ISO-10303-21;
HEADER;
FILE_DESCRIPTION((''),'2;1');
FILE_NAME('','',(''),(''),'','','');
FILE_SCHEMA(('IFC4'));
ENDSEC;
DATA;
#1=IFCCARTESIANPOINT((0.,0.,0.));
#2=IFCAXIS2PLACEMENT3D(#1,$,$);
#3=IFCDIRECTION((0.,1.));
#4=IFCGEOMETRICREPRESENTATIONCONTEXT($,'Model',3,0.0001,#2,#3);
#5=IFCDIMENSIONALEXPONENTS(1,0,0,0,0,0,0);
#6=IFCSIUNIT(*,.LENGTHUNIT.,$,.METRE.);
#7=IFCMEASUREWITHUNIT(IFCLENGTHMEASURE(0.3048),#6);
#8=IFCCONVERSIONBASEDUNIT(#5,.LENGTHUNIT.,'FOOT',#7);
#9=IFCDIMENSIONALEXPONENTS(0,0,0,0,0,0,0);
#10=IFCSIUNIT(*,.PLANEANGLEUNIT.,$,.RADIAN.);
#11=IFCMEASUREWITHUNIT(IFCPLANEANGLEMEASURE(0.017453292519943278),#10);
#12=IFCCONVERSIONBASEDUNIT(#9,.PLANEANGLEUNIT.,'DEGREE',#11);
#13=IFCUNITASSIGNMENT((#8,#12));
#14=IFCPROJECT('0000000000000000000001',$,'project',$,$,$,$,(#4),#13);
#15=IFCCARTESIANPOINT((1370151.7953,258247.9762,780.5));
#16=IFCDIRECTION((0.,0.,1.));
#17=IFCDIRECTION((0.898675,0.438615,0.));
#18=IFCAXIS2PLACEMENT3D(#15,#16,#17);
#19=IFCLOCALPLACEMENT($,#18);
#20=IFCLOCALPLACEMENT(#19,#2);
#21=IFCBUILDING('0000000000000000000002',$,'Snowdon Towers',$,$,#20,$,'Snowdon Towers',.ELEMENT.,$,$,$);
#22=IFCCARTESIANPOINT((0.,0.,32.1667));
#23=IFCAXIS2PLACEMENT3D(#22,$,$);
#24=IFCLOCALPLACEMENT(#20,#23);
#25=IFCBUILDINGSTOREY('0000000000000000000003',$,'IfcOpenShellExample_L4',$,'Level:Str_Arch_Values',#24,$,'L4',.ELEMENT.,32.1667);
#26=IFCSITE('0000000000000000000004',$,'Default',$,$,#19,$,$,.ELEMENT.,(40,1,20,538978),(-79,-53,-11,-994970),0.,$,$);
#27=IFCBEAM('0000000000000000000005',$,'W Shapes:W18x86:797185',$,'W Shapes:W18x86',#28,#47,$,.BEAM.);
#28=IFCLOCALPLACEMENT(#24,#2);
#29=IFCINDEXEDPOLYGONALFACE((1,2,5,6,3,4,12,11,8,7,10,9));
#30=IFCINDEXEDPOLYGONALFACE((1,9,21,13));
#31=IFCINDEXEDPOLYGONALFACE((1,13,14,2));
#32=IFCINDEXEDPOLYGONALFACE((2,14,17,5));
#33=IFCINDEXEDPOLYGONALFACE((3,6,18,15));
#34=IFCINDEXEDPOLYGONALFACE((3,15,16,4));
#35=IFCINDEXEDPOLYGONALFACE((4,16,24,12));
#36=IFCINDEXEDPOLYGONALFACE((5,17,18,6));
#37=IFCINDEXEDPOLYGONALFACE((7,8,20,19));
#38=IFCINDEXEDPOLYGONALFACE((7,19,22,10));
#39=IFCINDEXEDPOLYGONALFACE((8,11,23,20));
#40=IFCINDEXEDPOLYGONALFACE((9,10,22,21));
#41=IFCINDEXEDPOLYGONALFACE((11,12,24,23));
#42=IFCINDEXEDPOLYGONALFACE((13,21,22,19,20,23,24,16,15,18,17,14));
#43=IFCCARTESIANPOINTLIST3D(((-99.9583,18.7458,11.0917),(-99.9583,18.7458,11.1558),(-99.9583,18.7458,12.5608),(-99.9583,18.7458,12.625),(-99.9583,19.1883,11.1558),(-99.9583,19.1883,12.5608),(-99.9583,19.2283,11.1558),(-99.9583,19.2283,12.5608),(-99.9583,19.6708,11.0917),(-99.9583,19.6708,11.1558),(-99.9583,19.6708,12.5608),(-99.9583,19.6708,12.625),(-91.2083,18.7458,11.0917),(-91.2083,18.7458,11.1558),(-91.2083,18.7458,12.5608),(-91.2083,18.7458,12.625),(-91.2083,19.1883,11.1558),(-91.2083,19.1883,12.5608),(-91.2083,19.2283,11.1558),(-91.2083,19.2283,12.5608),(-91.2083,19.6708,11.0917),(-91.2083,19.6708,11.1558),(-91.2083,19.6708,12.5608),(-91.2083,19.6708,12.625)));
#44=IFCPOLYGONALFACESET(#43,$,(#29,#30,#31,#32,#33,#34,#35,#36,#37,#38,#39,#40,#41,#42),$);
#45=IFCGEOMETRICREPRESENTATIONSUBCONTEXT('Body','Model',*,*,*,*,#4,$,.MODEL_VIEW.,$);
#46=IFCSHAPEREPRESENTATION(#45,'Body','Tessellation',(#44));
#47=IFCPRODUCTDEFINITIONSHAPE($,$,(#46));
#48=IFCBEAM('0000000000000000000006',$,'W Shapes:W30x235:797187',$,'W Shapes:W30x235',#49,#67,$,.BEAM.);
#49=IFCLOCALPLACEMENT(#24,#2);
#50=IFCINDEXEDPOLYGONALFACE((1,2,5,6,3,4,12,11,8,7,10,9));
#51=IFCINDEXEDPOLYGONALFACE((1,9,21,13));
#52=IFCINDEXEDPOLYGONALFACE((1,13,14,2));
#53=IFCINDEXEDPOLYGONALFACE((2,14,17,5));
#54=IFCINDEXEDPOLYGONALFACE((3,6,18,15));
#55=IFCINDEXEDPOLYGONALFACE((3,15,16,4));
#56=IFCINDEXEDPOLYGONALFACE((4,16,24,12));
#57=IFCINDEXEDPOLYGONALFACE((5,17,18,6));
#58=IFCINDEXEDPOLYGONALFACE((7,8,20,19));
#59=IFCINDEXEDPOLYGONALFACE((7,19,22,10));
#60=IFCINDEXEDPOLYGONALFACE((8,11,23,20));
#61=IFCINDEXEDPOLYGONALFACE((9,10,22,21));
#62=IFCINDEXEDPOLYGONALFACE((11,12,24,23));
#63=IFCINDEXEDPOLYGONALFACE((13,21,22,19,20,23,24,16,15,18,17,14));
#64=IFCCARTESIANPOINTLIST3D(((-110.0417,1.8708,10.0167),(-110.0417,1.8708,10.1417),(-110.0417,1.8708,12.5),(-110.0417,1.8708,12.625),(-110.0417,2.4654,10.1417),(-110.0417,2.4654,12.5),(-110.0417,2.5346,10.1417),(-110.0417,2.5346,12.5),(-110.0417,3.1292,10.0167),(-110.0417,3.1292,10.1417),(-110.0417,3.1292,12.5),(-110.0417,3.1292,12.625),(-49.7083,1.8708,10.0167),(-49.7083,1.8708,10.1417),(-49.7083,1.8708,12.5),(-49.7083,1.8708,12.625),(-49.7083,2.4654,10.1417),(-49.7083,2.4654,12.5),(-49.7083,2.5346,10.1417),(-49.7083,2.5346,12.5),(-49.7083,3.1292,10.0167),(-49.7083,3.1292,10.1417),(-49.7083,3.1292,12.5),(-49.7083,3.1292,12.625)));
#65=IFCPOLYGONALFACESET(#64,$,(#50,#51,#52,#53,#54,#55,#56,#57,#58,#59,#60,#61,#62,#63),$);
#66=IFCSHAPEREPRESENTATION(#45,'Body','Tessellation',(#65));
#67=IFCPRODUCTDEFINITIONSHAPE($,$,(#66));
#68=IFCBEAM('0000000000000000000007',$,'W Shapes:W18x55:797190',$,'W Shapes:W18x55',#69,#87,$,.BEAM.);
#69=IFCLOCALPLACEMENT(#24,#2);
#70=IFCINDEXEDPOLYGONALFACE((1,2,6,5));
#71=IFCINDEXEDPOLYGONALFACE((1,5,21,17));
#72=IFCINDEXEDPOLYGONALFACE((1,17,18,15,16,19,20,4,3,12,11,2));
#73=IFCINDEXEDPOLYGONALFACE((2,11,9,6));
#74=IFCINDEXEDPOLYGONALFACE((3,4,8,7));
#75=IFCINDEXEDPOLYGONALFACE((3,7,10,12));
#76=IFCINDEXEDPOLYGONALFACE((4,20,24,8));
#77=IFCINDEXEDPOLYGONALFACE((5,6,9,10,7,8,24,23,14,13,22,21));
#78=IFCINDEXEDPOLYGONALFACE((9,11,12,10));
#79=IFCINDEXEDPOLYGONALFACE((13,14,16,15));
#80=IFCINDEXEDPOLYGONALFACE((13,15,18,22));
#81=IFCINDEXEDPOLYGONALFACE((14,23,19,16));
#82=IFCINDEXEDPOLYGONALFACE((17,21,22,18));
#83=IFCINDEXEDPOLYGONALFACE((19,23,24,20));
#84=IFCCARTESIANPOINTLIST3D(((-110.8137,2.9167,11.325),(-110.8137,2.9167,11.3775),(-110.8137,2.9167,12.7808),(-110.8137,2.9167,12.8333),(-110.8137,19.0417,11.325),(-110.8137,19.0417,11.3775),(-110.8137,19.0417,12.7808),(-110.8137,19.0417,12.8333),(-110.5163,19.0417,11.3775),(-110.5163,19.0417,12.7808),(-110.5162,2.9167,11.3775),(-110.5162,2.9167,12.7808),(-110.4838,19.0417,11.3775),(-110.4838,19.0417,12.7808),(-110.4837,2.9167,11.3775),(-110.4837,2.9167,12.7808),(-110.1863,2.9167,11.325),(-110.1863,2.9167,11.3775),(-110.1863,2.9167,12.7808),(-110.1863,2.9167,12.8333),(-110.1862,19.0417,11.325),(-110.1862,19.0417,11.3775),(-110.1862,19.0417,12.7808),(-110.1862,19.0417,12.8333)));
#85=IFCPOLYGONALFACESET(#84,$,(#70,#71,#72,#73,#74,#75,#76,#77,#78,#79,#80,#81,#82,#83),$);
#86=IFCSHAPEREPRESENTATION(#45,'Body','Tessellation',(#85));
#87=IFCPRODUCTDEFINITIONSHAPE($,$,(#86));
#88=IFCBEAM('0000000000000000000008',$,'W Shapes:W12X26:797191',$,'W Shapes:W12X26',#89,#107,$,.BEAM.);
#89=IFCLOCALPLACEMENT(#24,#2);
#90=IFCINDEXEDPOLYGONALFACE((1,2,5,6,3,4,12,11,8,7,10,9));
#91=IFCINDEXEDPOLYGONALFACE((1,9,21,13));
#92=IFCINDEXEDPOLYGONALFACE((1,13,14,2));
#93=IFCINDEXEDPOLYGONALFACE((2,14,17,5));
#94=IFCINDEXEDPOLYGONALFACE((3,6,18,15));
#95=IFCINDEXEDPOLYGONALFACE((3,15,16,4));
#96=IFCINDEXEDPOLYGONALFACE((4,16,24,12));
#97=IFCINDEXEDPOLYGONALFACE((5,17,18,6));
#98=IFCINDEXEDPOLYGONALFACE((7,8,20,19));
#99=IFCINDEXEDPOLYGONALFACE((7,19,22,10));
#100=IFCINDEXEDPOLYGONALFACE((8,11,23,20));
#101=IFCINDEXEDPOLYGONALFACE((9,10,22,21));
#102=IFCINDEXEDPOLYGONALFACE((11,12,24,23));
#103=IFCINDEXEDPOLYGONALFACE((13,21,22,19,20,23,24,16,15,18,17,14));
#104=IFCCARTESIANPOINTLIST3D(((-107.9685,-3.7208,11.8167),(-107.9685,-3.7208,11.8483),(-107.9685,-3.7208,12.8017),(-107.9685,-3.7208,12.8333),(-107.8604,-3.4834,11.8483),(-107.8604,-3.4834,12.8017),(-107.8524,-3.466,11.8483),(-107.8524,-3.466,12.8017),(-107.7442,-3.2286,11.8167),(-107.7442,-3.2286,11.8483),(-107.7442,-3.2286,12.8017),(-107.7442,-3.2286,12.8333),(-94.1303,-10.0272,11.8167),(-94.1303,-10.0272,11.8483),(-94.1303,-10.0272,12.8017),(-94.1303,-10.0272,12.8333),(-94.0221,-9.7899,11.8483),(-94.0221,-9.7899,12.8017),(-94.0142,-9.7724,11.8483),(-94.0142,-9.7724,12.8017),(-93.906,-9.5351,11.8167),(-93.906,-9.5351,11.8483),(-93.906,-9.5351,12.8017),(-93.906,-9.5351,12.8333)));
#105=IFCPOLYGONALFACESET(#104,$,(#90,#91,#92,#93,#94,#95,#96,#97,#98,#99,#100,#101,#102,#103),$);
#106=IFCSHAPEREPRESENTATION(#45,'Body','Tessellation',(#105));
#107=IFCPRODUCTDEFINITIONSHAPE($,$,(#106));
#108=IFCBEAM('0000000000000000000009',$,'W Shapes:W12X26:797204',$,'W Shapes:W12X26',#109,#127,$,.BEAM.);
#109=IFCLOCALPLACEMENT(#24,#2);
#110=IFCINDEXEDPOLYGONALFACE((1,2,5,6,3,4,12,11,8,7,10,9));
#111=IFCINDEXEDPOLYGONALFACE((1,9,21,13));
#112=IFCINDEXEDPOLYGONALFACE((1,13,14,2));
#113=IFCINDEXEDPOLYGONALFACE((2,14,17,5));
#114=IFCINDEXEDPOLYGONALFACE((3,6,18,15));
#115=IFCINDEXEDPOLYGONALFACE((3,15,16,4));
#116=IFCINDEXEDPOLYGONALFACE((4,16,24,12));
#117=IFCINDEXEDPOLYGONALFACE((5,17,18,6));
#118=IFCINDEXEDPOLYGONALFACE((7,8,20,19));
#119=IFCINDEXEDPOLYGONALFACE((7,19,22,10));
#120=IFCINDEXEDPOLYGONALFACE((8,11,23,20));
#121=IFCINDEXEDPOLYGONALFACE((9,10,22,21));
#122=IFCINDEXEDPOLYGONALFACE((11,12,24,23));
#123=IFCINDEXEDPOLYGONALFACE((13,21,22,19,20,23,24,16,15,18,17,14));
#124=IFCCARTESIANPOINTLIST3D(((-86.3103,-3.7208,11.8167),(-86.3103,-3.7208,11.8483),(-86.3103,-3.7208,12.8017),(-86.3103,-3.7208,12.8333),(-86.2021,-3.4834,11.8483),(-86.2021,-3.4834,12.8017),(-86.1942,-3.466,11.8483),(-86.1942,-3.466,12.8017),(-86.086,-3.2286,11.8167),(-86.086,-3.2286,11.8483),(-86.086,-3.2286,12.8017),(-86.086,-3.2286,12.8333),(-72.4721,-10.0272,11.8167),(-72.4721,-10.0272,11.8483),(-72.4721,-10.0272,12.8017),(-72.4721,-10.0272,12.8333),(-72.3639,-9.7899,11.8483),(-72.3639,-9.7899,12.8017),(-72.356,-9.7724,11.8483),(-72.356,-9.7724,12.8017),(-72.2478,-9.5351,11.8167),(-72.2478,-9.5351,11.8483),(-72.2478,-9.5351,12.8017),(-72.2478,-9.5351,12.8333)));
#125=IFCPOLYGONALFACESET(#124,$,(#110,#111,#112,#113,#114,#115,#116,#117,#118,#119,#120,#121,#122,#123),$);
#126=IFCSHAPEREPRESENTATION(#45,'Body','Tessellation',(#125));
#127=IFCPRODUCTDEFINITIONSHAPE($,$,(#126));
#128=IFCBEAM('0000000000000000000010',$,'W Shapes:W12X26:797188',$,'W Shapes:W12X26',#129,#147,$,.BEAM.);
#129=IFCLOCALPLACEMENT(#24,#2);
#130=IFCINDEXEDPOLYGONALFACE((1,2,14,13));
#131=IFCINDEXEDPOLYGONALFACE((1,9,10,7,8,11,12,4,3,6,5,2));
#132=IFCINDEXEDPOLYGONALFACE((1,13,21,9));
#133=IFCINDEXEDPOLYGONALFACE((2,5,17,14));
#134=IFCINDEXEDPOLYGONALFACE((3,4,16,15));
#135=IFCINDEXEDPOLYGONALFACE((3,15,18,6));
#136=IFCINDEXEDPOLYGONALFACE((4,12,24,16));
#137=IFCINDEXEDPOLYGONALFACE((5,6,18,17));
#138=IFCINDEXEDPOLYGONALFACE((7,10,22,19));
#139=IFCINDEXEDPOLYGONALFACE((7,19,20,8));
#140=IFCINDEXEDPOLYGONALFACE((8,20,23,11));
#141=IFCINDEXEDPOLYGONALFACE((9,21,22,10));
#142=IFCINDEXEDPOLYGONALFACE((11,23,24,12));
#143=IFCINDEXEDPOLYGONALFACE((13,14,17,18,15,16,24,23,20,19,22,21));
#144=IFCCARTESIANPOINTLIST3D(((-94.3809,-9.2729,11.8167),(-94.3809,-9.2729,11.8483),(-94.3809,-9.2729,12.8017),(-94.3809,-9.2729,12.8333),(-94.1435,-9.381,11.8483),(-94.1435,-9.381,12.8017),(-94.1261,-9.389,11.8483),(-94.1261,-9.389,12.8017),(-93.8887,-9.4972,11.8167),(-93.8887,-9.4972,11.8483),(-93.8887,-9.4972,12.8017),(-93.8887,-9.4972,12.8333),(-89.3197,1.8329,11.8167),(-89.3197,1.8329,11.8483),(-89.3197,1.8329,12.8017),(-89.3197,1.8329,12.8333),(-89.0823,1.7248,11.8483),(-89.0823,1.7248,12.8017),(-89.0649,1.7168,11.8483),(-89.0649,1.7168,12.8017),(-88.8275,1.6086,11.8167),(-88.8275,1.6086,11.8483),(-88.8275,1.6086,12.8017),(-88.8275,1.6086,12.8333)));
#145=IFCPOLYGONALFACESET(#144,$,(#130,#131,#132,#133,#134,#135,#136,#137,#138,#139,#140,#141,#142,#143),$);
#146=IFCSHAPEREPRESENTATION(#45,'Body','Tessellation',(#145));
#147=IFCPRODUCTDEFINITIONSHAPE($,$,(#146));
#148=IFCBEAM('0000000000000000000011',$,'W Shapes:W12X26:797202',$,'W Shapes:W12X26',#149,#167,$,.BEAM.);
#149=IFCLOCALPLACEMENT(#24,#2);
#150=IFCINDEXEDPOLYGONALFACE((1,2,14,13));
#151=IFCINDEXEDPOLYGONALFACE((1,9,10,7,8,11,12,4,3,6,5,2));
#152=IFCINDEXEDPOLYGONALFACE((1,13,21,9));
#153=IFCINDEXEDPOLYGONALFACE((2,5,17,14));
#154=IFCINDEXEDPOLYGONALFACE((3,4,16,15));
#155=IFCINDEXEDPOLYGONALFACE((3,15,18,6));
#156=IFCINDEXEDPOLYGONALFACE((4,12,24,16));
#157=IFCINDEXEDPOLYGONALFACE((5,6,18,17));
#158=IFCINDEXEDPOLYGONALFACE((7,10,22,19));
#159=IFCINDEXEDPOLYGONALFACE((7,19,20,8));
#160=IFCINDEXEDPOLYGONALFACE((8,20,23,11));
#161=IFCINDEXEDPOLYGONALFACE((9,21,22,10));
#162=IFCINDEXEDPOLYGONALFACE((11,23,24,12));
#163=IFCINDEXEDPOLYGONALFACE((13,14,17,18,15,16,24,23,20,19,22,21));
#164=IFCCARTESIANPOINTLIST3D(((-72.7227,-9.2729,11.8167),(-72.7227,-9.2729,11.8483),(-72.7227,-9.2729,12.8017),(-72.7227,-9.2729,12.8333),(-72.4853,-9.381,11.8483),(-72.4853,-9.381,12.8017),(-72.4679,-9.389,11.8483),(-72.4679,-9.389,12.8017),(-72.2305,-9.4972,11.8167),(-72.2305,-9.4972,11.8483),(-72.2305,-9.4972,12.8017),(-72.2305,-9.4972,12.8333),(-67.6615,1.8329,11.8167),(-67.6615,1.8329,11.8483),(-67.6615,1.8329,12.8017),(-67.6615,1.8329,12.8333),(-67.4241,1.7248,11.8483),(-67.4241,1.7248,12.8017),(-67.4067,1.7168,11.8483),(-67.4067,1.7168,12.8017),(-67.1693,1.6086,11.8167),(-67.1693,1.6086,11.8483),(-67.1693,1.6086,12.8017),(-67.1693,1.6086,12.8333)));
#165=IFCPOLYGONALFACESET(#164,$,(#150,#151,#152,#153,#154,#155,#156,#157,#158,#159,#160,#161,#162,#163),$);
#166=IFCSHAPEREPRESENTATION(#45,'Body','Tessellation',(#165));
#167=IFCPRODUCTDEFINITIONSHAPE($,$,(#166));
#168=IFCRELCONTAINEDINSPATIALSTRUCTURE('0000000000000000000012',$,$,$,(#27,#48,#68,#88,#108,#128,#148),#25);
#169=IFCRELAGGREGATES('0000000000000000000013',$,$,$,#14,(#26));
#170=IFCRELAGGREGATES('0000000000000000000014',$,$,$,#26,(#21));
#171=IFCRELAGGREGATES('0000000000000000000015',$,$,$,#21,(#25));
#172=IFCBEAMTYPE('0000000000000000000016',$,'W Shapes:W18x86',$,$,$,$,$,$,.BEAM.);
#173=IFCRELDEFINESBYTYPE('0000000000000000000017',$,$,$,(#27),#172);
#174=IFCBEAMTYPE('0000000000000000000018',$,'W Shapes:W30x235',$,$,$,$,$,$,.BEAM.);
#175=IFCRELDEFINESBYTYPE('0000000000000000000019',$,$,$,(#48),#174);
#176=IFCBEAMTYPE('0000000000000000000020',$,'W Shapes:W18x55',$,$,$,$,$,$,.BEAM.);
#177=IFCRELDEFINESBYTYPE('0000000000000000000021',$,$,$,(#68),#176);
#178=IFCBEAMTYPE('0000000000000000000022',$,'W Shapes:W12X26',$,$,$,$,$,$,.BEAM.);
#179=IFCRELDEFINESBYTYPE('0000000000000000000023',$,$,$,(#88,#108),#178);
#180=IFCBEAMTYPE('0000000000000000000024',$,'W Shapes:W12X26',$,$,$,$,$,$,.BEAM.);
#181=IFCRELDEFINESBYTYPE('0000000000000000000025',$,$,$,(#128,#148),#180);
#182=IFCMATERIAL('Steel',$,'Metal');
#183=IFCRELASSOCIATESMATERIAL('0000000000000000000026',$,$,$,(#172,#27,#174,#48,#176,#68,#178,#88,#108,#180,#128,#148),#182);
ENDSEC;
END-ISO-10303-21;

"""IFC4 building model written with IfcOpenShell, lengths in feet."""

from ifc_helpers import new_model, entity, si_unit, converted_unit, direction, frame, origin, place, context, subcontext, project, spatial, indexed_curve, outline, extrude, source, transform, mapped, material, type_object, type_shapes, element, save


model = new_model("IFC4")

# Units and contexts
model_context = context("Model", 3, precision=0.0001, world=origin(), true_north=direction((0.0, 1.0)))
body_context = subcontext(model_context, "Body", "Model", "MODEL_VIEW")
ifc_project = project(units=[converted_unit("LENGTHUNIT", "FOOT", entity("IfcLengthMeasure", 0.3048), si_unit("LENGTHUNIT", "METRE"), dimensions=[1, 0, 0, 0, 0, 0, 0]), converted_unit("PLANEANGLEUNIT", "DEGREE", entity("IfcPlaneAngleMeasure", 0.017453292519943278), si_unit("PLANEANGLEUNIT", "RADIAN"), dimensions=[0, 0, 0, 0, 0, 0, 0])], contexts=[model_context])

# Site, building, storey
site_placement = place(None, frame((1370151.7953, 258247.9762, 780.5), z_axis=(0.0, 0.0, 1.0), x_axis=(0.898675, 0.438615, 0.0)))
site = spatial("IfcSite", under=ifc_project, at=site_placement, Name="Default", CompositionType="ELEMENT", RefLatitude=(40, 1, 20, 538978), RefLongitude=(-79, -53, -11, -994970), RefElevation=0.0)
building_placement = place(site_placement, origin())
building = spatial("IfcBuilding", under=site, at=building_placement, Name="Snowdon Towers", LongName="Snowdon Towers", CompositionType="ELEMENT")
storey_placement = place(building_placement, frame((0.0, 0.0, 32.1667)))
storey = spatial("IfcBuildingStorey", under=building, at=storey_placement, Name="IfcOpenShellExample_L4", ObjectType="Level:Str_Arch_Values", LongName="L4", CompositionType="ELEMENT", Elevation=32.1667)

# Beams
ifc_material = material(Name="Steel", Category="Metal")
beam_type_1 = type_object("IfcBeamType", Name="W Shapes:W18x86", PredefinedType="BEAM", material=ifc_material)
shared_shape_1 = source(origin(), body_context, "Body", "SweptSolid", [
    extrude(outline(indexed_curve([(-0.4625, -0.7025), (-0.4625, -0.7667), (0.4625, -0.7667), (0.4625, -0.7025), (0.02, -0.7025), (0.02, 0.7025), (0.4625, 0.7025), (0.4625, 0.7667), (-0.4625, 0.7667), (-0.4625, 0.7025), (-0.02, 0.7025), (-0.02, -0.7025), (-0.4625, -0.7025)], self_intersect=False)), frame((-4.6042, 0.0, 0.0), z_axis=(-1.0, 0.0, 0.0), x_axis=(0.0, -1.0, 0.0)), (0.0, 0.0, -1.0), 8.75),
])
type_shapes(beam_type_1, [shared_shape_1])
beam_1_placement = place(storey_placement, frame((-95.3542, 19.2083, 11.8583)))
element("IfcBeam", 1, at=beam_1_placement, inside=storey, type_object=beam_type_1, material=ifc_material, Name="W Shapes:W18x86:797185", ObjectType="W Shapes:W18x86", PredefinedType="BEAM", context=body_context, shape_type="MappedRepresentation", body=[
    mapped(shared_shape_1, transform((0.0, 0.0, 0.0), scale=1.0)),
])
beam_type_2 = type_object("IfcBeamType", Name="W Shapes:W30x235", PredefinedType="BEAM", material=ifc_material)
shared_shape_2 = source(origin(), body_context, "Body", "SweptSolid", [
    extrude(outline(indexed_curve([(-0.6292, -1.1792), (-0.6292, -1.3042), (0.6292, -1.3042), (0.6292, -1.1792), (0.0346, -1.1792), (0.0346, 1.1792), (0.6292, 1.1792), (0.6292, 1.3042), (-0.6292, 1.3042), (-0.6292, 1.1792), (-0.0346, 1.1792), (-0.0346, -1.1792), (-0.6292, -1.1792)], self_intersect=False)), frame((-29.9167, 0.0, 0.0), z_axis=(-1.0, 0.0, 0.0), x_axis=(0.0, -1.0, 0.0)), (0.0, 0.0, -1.0), 60.3333),
])
type_shapes(beam_type_2, [shared_shape_2])
beam_2_placement = place(storey_placement, frame((-80.125, 2.5, 11.3208)))
element("IfcBeam", 2, at=beam_2_placement, inside=storey, type_object=beam_type_2, material=ifc_material, Name="W Shapes:W30x235:797187", ObjectType="W Shapes:W30x235", PredefinedType="BEAM", context=body_context, shape_type="MappedRepresentation", body=[
    mapped(shared_shape_2, transform((0.0, 0.0, 0.0), scale=1.0)),
])
beam_type_3 = type_object("IfcBeamType", Name="W Shapes:W18x55", PredefinedType="BEAM", material=ifc_material)
shared_shape_3 = source(origin(), body_context, "Body", "SweptSolid", [
    extrude(outline(indexed_curve([(-0.3138, -0.7017), (-0.3138, -0.7542), (0.3138, -0.7542), (0.3138, -0.7017), (0.0162, -0.7017), (0.0162, 0.7017), (0.3138, 0.7017), (0.3138, 0.7542), (-0.3137, 0.7542), (-0.3137, 0.7017), (-0.0163, 0.7017), (-0.0163, -0.7017), (-0.3138, -0.7017)], self_intersect=False)), frame((-7.8542, 0.0, 0.0), z_axis=(-1.0, 0.0, 0.0), x_axis=(0.0, -1.0, 0.0)), (0.0, 0.0, -1.0), 16.125),
])
type_shapes(beam_type_3, [shared_shape_3])
beam_3_placement = place(storey_placement, frame((-110.5, 10.7708, 12.0792), z_axis=(0.0, 0.0, 1.0), x_axis=(0.0, 1.0, 0.0)))
element("IfcBeam", 3, at=beam_3_placement, inside=storey, type_object=beam_type_3, material=ifc_material, Name="W Shapes:W18x55:797190", ObjectType="W Shapes:W18x55", PredefinedType="BEAM", context=body_context, shape_type="MappedRepresentation", body=[
    mapped(shared_shape_3, transform((0.0, 0.0, 0.0), scale=1.0)),
])

# Beams
beam_type_4 = type_object("IfcBeamType", Name="W Shapes:W12X26", PredefinedType="BEAM", material=ifc_material)
shared_shape_4 = source(origin(), body_context, "Body", "SweptSolid", [
    extrude(outline(indexed_curve([(-0.2704, -0.4767), (-0.2704, -0.5083), (0.2704, -0.5083), (0.2704, -0.4767), (0.0096, -0.4767), (0.0096, 0.4767), (0.2704, 0.4767), (0.2704, 0.5083), (-0.2704, 0.5083), (-0.2704, 0.4767), (-0.0096, 0.4767), (-0.0096, -0.4767), (-0.2704, -0.4767)], self_intersect=False)), frame((-7.6037, 0.0, 0.0), z_axis=(-1.0, 0.0, 0.0), x_axis=(0.0, -1.0, 0.0)), (0.0, 0.0, -1.0), 15.2075),
])
type_shapes(beam_type_4, [shared_shape_4])
for number, where, z_axis, x_axis, name in (
    (4, (-100.9373, -6.6279, 12.325), (0.0, 0.0, 1.0), (0.909961, -0.414693, 0.0), "W Shapes:W12X26:797191"),
    (5, (-79.2791, -6.6279, 12.325), (0.0, 0.0, 1.0), (0.909961, -0.414693, 0.0), "W Shapes:W12X26:797204"),
):
    element("IfcBeam", number, at=place(storey_placement, frame(where, z_axis=z_axis, x_axis=x_axis)), inside=storey, type_object=beam_type_4, material=ifc_material, Name=name, ObjectType="W Shapes:W12X26", PredefinedType="BEAM", context=body_context, shape_type="MappedRepresentation", body=[
        mapped(shared_shape_4, transform((0.0, 0.0, 0.0), scale=1.0)),
    ])
beam_type_5 = type_object("IfcBeamType", Name="W Shapes:W12X26", PredefinedType="BEAM", material=ifc_material)
shared_shape_5 = source(origin(), body_context, "Body", "SweptSolid", [
    extrude(outline(indexed_curve([(-0.2704, -0.4767), (-0.2704, -0.5083), (0.2704, -0.5083), (0.2704, -0.4767), (0.0096, -0.4767), (0.0096, 0.4767), (0.2704, 0.4767), (0.2704, 0.5083), (-0.2704, 0.5083), (-0.2704, 0.4767), (-0.0096, 0.4767), (-0.0096, -0.4767), (-0.2704, -0.4767)], self_intersect=False)), frame((-6.3745, 0.0, 0.0), z_axis=(-1.0, 0.0, 0.0), x_axis=(0.0, -1.0, 0.0)), (0.0, 0.0, -1.0), 12.2047),
])
type_shapes(beam_type_5, [shared_shape_5])
for number, where, z_axis, x_axis, name in (
    (6, (-91.4913, -3.5845, 12.325), (0.0, 0.0, 1.0), (0.414693, 0.909961, 0.0), "W Shapes:W12X26:797188"),
    (7, (-69.8331, -3.5845, 12.325), (0.0, 0.0, 1.0), (0.414693, 0.909961, 0.0), "W Shapes:W12X26:797202"),
):
    element("IfcBeam", number, at=place(storey_placement, frame(where, z_axis=z_axis, x_axis=x_axis)), inside=storey, type_object=beam_type_5, material=ifc_material, Name=name, ObjectType="W Shapes:W12X26", PredefinedType="BEAM", context=body_context, shape_type="MappedRepresentation", body=[
        mapped(shared_shape_5, transform((0.0, 0.0, 0.0), scale=1.0)),
    ])

save(model, "model.ifc")
